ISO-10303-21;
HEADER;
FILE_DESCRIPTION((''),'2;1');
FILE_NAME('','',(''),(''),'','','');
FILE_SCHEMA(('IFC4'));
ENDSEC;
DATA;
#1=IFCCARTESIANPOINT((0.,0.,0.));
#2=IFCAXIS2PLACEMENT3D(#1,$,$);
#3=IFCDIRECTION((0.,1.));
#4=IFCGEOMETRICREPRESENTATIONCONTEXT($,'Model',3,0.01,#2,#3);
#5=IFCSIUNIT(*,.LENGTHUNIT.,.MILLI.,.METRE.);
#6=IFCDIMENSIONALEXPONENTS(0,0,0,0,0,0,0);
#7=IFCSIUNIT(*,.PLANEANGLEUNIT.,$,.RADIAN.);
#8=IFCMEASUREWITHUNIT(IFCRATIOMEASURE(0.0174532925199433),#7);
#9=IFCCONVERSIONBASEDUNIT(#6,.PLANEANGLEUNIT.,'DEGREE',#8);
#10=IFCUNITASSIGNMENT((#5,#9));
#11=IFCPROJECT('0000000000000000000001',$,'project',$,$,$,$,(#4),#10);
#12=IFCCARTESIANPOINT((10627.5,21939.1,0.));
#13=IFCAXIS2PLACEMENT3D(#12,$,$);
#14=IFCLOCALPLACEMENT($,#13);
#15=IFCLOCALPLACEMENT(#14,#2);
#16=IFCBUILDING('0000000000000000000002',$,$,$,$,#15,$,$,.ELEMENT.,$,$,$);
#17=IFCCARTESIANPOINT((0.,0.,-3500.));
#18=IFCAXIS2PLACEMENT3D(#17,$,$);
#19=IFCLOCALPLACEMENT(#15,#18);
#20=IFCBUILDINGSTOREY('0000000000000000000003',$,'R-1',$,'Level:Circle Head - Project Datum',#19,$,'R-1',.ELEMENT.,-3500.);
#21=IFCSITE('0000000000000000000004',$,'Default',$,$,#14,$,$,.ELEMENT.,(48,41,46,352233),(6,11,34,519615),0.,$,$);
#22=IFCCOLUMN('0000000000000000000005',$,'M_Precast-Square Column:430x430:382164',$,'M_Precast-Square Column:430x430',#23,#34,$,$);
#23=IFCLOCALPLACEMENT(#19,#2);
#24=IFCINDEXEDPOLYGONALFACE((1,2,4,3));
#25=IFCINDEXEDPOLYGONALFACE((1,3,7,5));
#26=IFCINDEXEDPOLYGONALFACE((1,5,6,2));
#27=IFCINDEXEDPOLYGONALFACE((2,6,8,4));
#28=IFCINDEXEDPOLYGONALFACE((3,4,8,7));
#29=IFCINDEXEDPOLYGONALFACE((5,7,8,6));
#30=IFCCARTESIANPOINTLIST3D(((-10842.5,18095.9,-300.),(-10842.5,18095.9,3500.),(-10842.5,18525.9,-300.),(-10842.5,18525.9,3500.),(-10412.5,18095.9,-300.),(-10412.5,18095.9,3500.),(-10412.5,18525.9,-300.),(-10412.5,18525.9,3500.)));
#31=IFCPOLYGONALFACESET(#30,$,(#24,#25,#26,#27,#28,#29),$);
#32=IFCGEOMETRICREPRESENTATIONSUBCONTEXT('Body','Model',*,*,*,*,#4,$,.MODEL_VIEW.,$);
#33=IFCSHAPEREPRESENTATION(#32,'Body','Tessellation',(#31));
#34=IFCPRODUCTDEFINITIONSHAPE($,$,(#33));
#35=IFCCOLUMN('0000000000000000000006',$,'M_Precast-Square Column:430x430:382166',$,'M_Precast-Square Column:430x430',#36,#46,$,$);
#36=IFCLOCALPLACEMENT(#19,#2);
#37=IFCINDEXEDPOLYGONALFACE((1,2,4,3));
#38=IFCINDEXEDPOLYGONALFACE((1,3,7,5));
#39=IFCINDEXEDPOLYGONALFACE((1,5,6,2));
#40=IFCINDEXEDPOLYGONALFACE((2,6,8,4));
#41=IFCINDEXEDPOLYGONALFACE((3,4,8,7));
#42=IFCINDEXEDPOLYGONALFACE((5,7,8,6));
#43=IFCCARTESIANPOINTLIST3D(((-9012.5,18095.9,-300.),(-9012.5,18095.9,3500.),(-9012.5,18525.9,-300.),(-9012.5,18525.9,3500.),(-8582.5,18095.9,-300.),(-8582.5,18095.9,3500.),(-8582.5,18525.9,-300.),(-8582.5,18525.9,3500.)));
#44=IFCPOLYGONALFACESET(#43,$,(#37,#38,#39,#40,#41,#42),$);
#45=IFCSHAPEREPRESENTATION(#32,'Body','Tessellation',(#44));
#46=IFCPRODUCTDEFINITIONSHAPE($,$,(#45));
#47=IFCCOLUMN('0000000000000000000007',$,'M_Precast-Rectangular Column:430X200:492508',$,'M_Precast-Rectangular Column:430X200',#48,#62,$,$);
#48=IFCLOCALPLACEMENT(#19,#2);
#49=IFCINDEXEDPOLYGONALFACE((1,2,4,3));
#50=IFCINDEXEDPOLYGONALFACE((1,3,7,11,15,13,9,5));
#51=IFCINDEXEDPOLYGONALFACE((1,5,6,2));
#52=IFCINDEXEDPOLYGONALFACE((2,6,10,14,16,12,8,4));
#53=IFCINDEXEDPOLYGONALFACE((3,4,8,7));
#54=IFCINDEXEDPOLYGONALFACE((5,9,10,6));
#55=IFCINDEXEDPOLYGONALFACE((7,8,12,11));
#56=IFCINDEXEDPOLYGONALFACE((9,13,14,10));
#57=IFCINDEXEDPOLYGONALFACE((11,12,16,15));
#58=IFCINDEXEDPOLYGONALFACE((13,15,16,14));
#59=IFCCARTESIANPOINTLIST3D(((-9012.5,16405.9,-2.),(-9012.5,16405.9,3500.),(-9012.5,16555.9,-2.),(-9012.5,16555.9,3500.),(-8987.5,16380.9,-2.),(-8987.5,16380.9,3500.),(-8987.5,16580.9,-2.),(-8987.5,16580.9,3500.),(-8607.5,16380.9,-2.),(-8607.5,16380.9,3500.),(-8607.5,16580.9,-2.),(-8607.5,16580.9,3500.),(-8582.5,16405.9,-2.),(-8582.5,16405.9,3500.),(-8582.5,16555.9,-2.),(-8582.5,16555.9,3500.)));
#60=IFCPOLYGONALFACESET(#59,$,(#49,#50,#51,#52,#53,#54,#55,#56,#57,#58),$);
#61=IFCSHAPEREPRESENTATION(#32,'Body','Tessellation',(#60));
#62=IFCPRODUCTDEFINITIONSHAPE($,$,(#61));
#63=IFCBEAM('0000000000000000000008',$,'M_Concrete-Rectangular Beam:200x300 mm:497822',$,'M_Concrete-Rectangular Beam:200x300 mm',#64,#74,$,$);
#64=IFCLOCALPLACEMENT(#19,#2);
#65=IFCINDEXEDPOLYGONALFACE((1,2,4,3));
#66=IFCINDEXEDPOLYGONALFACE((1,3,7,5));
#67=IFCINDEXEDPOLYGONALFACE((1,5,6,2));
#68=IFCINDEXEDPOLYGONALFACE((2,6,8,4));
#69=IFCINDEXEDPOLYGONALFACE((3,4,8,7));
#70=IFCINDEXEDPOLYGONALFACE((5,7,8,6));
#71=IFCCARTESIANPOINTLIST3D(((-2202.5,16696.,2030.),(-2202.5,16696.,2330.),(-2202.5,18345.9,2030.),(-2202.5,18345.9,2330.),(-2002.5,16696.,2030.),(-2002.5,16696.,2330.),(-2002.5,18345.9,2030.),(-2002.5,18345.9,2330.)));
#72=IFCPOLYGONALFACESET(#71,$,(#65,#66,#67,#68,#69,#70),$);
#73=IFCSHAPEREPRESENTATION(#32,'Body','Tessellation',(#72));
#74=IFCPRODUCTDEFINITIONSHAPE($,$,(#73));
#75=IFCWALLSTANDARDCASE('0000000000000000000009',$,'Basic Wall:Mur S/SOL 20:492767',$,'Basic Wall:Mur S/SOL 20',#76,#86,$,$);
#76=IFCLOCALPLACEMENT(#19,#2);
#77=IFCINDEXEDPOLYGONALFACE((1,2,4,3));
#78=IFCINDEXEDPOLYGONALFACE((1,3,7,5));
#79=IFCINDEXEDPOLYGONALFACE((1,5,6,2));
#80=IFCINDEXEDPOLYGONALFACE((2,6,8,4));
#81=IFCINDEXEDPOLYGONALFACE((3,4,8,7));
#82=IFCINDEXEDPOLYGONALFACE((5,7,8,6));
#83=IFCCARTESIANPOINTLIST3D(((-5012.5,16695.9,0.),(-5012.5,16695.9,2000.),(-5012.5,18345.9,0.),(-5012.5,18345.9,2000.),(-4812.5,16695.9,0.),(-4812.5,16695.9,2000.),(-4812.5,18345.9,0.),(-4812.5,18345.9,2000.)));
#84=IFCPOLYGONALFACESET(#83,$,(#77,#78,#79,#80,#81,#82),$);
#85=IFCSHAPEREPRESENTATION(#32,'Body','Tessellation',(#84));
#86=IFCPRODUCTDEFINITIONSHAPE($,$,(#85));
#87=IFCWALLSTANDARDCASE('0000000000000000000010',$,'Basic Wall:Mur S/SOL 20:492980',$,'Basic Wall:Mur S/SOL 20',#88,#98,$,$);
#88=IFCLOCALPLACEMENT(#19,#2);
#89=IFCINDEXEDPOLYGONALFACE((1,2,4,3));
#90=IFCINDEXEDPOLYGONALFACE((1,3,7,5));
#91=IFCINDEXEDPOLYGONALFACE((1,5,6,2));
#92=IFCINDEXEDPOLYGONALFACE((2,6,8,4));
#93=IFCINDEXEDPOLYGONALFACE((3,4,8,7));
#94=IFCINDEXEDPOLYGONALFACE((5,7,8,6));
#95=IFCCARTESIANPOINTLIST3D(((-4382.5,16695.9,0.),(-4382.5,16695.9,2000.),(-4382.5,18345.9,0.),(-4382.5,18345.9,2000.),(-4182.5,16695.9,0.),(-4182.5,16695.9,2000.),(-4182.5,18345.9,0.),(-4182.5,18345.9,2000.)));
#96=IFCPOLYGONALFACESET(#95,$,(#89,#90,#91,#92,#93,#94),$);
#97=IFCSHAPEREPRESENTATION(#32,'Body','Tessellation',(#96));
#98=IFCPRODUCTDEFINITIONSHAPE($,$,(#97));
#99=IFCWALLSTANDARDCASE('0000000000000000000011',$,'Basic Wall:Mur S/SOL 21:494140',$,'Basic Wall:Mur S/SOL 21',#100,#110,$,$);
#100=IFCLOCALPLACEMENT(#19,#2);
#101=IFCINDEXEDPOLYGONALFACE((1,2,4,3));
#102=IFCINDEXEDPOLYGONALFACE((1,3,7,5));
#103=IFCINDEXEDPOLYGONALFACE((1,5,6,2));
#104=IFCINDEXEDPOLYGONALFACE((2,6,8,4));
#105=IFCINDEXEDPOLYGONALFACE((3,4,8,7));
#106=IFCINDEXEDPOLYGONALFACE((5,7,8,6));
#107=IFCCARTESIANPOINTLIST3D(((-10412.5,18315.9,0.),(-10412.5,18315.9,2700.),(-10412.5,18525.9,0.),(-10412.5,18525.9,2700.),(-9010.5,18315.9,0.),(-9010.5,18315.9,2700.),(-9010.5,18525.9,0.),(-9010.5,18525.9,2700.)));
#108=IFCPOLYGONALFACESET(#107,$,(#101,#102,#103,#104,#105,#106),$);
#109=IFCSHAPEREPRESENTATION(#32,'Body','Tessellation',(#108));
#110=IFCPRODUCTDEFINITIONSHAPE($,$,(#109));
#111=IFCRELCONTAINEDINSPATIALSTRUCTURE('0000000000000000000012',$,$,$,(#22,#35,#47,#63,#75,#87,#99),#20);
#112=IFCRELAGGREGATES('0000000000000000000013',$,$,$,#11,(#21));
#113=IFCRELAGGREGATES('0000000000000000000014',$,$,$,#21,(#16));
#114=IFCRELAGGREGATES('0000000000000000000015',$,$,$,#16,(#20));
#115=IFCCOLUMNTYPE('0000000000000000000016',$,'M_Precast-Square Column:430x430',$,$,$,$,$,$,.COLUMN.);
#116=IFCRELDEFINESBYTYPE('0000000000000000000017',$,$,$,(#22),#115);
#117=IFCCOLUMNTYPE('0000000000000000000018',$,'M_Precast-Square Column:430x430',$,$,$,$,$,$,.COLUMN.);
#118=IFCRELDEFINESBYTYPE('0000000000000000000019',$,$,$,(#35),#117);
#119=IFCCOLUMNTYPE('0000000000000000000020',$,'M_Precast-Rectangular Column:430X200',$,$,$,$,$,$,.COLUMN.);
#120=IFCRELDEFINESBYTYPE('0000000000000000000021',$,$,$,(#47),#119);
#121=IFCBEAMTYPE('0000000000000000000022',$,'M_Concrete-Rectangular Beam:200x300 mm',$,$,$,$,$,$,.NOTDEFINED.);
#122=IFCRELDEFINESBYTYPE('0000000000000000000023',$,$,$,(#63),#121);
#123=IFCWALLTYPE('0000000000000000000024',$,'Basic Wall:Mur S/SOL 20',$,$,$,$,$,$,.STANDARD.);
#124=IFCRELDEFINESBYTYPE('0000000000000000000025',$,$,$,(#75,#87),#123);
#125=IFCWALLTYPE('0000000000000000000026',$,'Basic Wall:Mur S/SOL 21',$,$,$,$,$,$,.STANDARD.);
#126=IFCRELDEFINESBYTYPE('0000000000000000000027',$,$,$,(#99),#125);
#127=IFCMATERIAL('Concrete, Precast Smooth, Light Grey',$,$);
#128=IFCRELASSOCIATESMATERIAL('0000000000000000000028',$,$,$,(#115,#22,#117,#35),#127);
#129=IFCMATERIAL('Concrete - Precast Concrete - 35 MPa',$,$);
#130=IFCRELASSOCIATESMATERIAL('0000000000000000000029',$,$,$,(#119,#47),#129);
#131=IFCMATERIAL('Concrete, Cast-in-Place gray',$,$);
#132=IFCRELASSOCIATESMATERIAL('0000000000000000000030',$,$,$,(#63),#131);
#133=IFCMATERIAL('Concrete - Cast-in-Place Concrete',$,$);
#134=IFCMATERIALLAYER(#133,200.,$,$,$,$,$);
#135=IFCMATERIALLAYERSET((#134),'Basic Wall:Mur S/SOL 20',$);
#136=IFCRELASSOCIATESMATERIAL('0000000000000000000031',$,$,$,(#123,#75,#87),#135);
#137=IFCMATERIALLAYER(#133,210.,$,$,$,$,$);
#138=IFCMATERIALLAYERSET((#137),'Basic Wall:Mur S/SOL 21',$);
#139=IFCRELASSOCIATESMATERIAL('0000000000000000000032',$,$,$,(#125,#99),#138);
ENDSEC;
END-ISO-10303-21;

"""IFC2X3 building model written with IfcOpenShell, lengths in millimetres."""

from ifc_helpers import new_model, entity, si_unit, converted_unit, direction, frame, frame_2d, origin, place, context, subcontext, project, spatial, polyline, rectangle, outline, extrude, source, transform, mapped, material, layer, layer_set, layer_usage, type_object, type_shapes, element, save


model = new_model("IFC2X3")

# Units and contexts
model_context = context("Model", 3, precision=0.01, world=origin(), true_north=direction((0.0, 1.0)))
body_context = subcontext(model_context, "Body", "Model", "MODEL_VIEW")
ifc_project = project(units=[si_unit("LENGTHUNIT", "METRE", prefix="MILLI"), converted_unit("PLANEANGLEUNIT", "DEGREE", entity("IfcRatioMeasure", 0.0174532925199433), si_unit("PLANEANGLEUNIT", "RADIAN"), dimensions=[0, 0, 0, 0, 0, 0, 0])], contexts=[model_context])

# Site, building, storey
site_placement = place(None, frame((10627.5, 21939.1, 0.0)))
site = spatial("IfcSite", under=ifc_project, at=site_placement, Name="Default", CompositionType="ELEMENT", RefLatitude=(48, 41, 46, 352233), RefLongitude=(6, 11, 34, 519615), RefElevation=0.0)
building_placement = place(site_placement, origin())
building = spatial("IfcBuilding", under=site, at=building_placement, CompositionType="ELEMENT")
storey_placement = place(building_placement, frame((0.0, 0.0, -3500.0)))
storey = spatial("IfcBuildingStorey", under=building, at=storey_placement, Name="R-1", ObjectType="Level:Circle Head - Project Datum", LongName="R-1", CompositionType="ELEMENT", Elevation=-3500.0)

# Columns
ifc_material_1 = material(Name="Concrete, Precast Smooth, Light Grey")
column_type_1 = type_object("IfcColumnType", Name="M_Precast-Square Column:430x430", PredefinedType="COLUMN", material=ifc_material_1)
shared_shape_1 = source(origin(), body_context, "Body", "SweptSolid", [
    extrude(rectangle(XDim=430.0, YDim=430.0, at=frame_2d((0.0, 0.0), x_axis=(1.0, 0.0))), frame((-10627.5, 18310.9, -3800.0), z_axis=(0.0, 0.0, 1.0), x_axis=(0.0, -1.0, 0.0)), (0.0, 0.0, 1.0), 3800.0),
])
type_shapes(column_type_1, [shared_shape_1])
column_1_placement = place(storey_placement, frame((0.0, 0.0, 3500.0)))
element("IfcColumn", 1, at=column_1_placement, inside=storey, type_object=column_type_1, material=ifc_material_1, Name="M_Precast-Square Column:430x430:382164", ObjectType="M_Precast-Square Column:430x430", context=body_context, shape_type="MappedRepresentation", body=[
    mapped(shared_shape_1, transform((0.0, 0.0, 0.0), scale=1.0)),
])
column_type_2 = type_object("IfcColumnType", Name="M_Precast-Square Column:430x430", PredefinedType="COLUMN", material=ifc_material_1)
shared_shape_2 = source(origin(), body_context, "Body", "SweptSolid", [
    extrude(rectangle(XDim=430.0, YDim=430.0, at=frame_2d((0.0, 0.0), x_axis=(1.0, 0.0))), frame((-8797.5, 18310.9, -3800.0), z_axis=(0.0, 0.0, 1.0), x_axis=(0.0, -1.0, 0.0)), (0.0, 0.0, 1.0), 3800.0),
])
type_shapes(column_type_2, [shared_shape_2])
column_2_placement = place(storey_placement, frame((0.0, 0.0, 3500.0)))
element("IfcColumn", 2, at=column_2_placement, inside=storey, type_object=column_type_2, material=ifc_material_1, Name="M_Precast-Square Column:430x430:382166", ObjectType="M_Precast-Square Column:430x430", context=body_context, shape_type="MappedRepresentation", body=[
    mapped(shared_shape_2, transform((0.0, 0.0, 0.0), scale=1.0)),
])
ifc_material_2 = material(Name="Concrete - Precast Concrete - 35 MPa")
column_type_3 = type_object("IfcColumnType", Name="M_Precast-Rectangular Column:430X200", PredefinedType="COLUMN", material=ifc_material_2)
shared_shape_3 = source(origin(), body_context, "Body", "SweptSolid", [
    extrude(outline(polyline([(-75.0, -215.0), (75.0, -215.0), (100.0, -190.0), (100.0, 190.0), (75.0, 215.0), (-75.0, 215.0), (-100.0, 190.0), (-100.0, -190.0), (-75.0, -215.0)])), frame((0.0, 0.0, -3502.0), z_axis=(0.0, 0.0, 1.0), x_axis=(0.0, -1.0, 0.0)), (0.0, 0.0, 1.0), 3502.0),
])
type_shapes(column_type_3, [shared_shape_3])
column_3_placement = place(storey_placement, frame((-8797.5, 16480.9, 3500.0)))
element("IfcColumn", 3, at=column_3_placement, inside=storey, type_object=column_type_3, material=ifc_material_2, Name="M_Precast-Rectangular Column:430X200:492508", ObjectType="M_Precast-Rectangular Column:430X200", context=body_context, shape_type="MappedRepresentation", body=[
    mapped(shared_shape_3, transform((0.0, 0.0, 0.0), scale=1.0)),
])

# Beam
ifc_material_3 = material(Name="Concrete, Cast-in-Place gray")
beam_type = type_object("IfcBeamType", Name="M_Concrete-Rectangular Beam:200x300 mm", PredefinedType="NOTDEFINED")
beam_placement = place(storey_placement, frame((-2102.5, 16696.0, 2330.0), z_axis=(0.0, 0.0, 1.0), x_axis=(0.0, 1.0, 0.0)))
element("IfcBeam", 4, at=beam_placement, inside=storey, type_object=beam_type, material=ifc_material_3, Name="M_Concrete-Rectangular Beam:200x300 mm:497822", ObjectType="M_Concrete-Rectangular Beam:200x300 mm", context=body_context, shape_type="SweptSolid", body=[
    extrude(rectangle(XDim=300.0, YDim=200.0, at=frame_2d((0.0, 0.0), x_axis=(1.0, 0.0))), frame((0.0, 0.0, -150.0), z_axis=(1.0, 0.0, 0.0), x_axis=(0.0, 0.0, -1.0)), (0.0, 0.0, 1.0), 1650.0),
])

# Walls
ifc_material_4 = material(Name="Concrete - Cast-in-Place Concrete")
ifc_layer_1 = layer(ifc_material_4, 200.0)
ifc_layer_set_1 = layer_set([ifc_layer_1], Name="Basic Wall:Mur S/SOL 20")
ifc_layer_usage_1 = layer_usage(ifc_layer_set_1, "AXIS2", "NEGATIVE", 100.0)
wall_type_1 = type_object("IfcWallType", Name="Basic Wall:Mur S/SOL 20", PredefinedType="STANDARD", material=ifc_layer_set_1)
wall_1_placement = place(storey_placement, frame((-4912.5, 18345.9, 0.0), z_axis=(0.0, 0.0, 1.0), x_axis=(0.0, -1.0, 0.0)))
element("IfcWallStandardCase", 5, at=wall_1_placement, inside=storey, type_object=wall_type_1, material=ifc_layer_usage_1, Name="Basic Wall:Mur S/SOL 20:492767", ObjectType="Basic Wall:Mur S/SOL 20", context=body_context, shape_type="SweptSolid", body=[
    extrude(rectangle(XDim=1650.0, YDim=200.0, at=frame_2d((825.0, 0.0), x_axis=(-1.0, 0.0))), origin(), (0.0, 0.0, 1.0), 2000.0),
])
ifc_layer_usage_2 = layer_usage(ifc_layer_set_1, "AXIS2", "NEGATIVE", 100.0)
wall_2_placement = place(storey_placement, frame((-4282.5, 18345.9, 0.0), z_axis=(0.0, 0.0, 1.0), x_axis=(0.0, -1.0, 0.0)))
element("IfcWallStandardCase", 6, at=wall_2_placement, inside=storey, type_object=wall_type_1, material=ifc_layer_usage_2, Name="Basic Wall:Mur S/SOL 20:492980", ObjectType="Basic Wall:Mur S/SOL 20", context=body_context, shape_type="SweptSolid", body=[
    extrude(rectangle(XDim=1650.0, YDim=200.0, at=frame_2d((825.0, 0.0), x_axis=(-1.0, 0.0))), origin(), (0.0, 0.0, 1.0), 2000.0),
])
ifc_layer_2 = layer(ifc_material_4, 210.0)
ifc_layer_set_2 = layer_set([ifc_layer_2], Name="Basic Wall:Mur S/SOL 21")
ifc_layer_usage_3 = layer_usage(ifc_layer_set_2, "AXIS2", "NEGATIVE", 105.0)
wall_type_2 = type_object("IfcWallType", Name="Basic Wall:Mur S/SOL 21", PredefinedType="STANDARD", material=ifc_layer_set_2)
wall_3_placement = place(storey_placement, frame((-10412.5, 18420.9, 0.0)))
element("IfcWallStandardCase", 7, at=wall_3_placement, inside=storey, type_object=wall_type_2, material=ifc_layer_usage_3, Name="Basic Wall:Mur S/SOL 21:494140", ObjectType="Basic Wall:Mur S/SOL 21", context=body_context, shape_type="SweptSolid", body=[
    extrude(rectangle(XDim=1402.0, YDim=210.0, at=frame_2d((701.0, 0.0), x_axis=(-1.0, 0.0))), origin(), (0.0, 0.0, 1.0), 2700.0),
])

save(model, "model.ifc")
